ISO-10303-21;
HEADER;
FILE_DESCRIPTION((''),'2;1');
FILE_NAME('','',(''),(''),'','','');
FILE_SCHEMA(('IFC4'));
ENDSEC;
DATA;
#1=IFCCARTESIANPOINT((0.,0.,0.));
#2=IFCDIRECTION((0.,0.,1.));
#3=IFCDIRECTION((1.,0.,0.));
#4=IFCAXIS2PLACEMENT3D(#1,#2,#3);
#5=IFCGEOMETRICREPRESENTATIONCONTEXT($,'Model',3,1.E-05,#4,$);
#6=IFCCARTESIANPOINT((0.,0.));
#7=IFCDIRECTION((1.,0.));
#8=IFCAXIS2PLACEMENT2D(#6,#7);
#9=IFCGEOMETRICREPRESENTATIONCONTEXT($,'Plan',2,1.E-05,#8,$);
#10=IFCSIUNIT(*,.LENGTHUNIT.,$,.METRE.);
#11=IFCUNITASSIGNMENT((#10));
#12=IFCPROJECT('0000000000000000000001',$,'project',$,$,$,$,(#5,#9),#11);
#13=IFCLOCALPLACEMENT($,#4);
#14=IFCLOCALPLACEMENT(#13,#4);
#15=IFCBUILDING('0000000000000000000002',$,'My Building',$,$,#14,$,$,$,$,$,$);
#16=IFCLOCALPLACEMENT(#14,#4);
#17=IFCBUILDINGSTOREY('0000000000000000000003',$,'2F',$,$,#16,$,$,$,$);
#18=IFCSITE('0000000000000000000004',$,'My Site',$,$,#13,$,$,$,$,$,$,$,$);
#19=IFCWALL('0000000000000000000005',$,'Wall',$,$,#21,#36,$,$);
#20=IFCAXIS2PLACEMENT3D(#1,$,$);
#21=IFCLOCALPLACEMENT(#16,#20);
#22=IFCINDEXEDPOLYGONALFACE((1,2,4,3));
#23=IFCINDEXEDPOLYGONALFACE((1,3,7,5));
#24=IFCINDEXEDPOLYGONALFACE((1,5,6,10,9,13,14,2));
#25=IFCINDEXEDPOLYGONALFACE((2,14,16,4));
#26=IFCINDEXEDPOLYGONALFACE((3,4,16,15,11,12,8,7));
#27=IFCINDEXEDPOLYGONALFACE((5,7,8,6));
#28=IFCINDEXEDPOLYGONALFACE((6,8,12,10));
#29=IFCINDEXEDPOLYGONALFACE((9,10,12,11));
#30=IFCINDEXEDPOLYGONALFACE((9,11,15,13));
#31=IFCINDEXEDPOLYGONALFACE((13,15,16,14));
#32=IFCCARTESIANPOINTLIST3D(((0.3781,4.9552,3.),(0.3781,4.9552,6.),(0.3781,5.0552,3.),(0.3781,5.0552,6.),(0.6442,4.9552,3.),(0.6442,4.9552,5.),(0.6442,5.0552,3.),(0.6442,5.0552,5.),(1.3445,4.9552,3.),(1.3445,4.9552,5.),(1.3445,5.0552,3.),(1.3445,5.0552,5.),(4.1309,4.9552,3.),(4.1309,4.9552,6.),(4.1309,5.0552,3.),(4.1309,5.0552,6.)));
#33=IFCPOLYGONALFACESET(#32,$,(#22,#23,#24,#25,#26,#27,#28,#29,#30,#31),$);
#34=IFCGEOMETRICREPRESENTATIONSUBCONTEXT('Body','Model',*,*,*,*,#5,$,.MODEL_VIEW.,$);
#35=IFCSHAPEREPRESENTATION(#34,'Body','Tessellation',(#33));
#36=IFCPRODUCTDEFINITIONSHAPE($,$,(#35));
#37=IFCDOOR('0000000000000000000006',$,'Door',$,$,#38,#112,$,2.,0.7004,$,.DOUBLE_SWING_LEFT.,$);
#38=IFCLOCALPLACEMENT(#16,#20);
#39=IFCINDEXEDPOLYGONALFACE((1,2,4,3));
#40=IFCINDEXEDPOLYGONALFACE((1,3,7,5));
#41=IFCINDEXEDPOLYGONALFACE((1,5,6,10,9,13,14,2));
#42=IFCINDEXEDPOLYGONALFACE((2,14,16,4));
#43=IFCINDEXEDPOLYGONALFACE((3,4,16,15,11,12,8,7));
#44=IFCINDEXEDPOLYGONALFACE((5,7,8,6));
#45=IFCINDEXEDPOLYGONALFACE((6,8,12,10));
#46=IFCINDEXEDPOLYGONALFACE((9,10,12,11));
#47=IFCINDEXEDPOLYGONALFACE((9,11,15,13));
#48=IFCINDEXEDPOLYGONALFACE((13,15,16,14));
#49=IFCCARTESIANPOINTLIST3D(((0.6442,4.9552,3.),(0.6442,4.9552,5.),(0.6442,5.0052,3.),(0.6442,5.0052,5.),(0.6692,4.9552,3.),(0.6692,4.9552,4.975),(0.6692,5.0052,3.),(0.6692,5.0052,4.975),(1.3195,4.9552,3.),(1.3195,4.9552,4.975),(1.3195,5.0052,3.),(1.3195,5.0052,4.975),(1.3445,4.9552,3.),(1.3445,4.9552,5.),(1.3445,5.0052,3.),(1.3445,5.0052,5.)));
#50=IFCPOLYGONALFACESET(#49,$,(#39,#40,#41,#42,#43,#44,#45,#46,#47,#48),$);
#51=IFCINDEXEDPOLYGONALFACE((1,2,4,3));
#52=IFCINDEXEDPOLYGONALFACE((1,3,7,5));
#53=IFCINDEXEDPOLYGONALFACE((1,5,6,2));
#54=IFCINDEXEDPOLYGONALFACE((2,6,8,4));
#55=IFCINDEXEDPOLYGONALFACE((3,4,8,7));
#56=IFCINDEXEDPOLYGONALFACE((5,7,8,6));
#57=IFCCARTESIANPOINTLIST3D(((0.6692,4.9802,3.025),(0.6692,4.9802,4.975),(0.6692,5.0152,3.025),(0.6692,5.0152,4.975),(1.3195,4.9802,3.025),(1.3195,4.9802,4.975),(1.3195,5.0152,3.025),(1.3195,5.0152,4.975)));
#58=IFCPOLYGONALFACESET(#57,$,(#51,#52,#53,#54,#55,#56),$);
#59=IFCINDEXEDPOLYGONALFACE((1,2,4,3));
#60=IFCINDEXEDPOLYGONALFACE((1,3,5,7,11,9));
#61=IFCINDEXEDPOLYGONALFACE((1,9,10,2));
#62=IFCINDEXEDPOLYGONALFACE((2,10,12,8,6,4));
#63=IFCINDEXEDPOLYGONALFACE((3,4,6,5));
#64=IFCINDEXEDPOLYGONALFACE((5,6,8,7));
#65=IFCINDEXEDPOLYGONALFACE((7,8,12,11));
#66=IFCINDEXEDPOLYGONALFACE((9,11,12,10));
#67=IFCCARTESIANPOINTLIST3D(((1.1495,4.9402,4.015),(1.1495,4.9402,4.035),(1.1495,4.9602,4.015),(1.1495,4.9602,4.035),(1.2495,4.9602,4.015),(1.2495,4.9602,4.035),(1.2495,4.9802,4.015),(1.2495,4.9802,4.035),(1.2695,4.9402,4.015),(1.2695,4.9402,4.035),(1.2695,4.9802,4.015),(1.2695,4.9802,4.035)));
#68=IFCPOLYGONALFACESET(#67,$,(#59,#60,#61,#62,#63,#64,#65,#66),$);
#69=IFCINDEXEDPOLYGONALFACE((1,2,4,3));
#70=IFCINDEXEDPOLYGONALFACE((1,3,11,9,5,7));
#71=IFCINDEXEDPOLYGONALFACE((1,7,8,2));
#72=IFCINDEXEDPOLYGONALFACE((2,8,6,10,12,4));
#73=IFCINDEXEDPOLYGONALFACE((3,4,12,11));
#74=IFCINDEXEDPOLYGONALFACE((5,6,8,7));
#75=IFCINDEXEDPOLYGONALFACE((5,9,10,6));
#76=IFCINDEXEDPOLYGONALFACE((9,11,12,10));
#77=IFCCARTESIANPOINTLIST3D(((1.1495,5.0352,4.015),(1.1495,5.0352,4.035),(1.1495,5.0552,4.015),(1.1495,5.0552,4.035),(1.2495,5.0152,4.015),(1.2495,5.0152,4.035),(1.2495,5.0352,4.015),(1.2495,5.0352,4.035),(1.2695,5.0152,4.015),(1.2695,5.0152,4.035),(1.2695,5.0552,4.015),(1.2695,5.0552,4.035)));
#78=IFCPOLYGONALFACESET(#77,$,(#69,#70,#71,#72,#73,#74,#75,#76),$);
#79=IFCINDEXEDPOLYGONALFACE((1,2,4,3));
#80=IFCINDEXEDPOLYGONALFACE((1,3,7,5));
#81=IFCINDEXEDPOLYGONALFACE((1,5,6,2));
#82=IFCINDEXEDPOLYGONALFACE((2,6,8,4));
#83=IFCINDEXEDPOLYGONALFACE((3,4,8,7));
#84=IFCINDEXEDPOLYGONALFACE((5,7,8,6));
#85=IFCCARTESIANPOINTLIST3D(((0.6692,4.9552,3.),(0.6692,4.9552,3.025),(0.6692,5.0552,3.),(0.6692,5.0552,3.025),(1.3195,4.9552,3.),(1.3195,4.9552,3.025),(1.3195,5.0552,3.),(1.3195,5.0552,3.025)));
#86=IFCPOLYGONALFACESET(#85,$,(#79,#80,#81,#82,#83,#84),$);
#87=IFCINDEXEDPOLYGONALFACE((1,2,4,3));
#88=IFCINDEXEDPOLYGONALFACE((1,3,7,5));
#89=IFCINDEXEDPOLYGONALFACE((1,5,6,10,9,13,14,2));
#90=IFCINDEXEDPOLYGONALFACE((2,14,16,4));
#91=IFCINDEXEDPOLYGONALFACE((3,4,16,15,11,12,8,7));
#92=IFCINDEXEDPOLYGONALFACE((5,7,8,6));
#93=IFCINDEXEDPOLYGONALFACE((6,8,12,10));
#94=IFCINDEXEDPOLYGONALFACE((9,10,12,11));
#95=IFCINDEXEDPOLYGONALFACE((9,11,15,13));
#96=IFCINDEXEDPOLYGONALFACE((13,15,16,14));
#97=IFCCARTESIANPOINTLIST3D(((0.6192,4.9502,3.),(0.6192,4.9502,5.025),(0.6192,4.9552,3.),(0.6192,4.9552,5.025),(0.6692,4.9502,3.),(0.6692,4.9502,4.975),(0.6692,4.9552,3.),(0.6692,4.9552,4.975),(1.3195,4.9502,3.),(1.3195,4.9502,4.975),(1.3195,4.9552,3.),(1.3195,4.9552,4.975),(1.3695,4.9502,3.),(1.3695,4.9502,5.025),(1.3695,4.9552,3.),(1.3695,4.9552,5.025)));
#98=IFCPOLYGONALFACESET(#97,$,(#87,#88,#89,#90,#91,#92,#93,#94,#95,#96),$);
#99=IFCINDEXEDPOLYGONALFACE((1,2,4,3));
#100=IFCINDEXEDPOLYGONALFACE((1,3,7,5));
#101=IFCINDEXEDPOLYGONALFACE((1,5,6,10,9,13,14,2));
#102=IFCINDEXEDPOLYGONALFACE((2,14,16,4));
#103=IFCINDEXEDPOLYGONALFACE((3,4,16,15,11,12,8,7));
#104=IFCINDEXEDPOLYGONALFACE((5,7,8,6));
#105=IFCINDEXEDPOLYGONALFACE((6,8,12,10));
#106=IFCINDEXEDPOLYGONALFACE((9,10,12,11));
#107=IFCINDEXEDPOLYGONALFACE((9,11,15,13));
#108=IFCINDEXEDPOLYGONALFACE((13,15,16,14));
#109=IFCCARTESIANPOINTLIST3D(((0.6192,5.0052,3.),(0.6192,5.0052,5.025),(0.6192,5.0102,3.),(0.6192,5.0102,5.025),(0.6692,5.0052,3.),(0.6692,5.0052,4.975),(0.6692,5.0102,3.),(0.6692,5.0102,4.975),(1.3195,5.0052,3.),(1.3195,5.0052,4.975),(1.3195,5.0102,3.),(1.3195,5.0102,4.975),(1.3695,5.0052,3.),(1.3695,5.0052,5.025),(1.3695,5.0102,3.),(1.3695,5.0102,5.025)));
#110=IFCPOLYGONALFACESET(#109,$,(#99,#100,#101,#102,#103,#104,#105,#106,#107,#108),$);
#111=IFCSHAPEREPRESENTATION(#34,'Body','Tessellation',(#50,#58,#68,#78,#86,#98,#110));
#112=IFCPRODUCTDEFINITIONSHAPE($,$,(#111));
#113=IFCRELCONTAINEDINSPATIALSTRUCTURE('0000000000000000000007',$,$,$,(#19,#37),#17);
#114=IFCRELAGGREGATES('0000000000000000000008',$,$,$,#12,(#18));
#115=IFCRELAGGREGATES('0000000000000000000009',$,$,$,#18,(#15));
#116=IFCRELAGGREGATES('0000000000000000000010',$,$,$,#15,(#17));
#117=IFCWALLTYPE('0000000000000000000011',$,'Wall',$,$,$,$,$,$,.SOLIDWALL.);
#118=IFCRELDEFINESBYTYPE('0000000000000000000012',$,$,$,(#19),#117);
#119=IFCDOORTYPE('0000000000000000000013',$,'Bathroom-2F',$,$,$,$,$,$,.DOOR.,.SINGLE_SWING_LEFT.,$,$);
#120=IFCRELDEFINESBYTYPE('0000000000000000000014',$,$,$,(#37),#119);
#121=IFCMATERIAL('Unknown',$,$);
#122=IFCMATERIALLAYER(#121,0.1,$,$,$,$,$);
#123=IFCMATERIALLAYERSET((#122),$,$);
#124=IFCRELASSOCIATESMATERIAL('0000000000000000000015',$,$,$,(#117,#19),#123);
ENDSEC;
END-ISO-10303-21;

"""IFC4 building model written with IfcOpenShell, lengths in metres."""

from ifc_helpers import new_model, entity, si_unit, frame, origin_with_axes, origin_2d_with_axis, place, context, subcontext, project, spatial, line, indexed_curve, outline, extrude, shape, source, transform, mapped, material, layer, layer_set, layer_usage, type_object, type_shapes, element, fill, save


model = new_model("IFC4")

# Units and contexts
model_context = context("Model", 3, precision=1e-05, world=origin_with_axes())
plan_context = context("Plan", 2, precision=1e-05, world=origin_2d_with_axis())
body_context_1 = subcontext(model_context, "Body", "Model", "MODEL_VIEW")
body_context_2 = subcontext(plan_context, "Body", "Plan", "PLAN_VIEW")
ifc_project = project(units=[si_unit("LENGTHUNIT", "METRE")], contexts=[model_context, plan_context])

# Site, building, storey
site_placement = place(None, origin_with_axes())
site = spatial("IfcSite", under=ifc_project, at=site_placement, Name="My Site")
building_placement = place(site_placement, origin_with_axes())
building = spatial("IfcBuilding", under=site, at=building_placement, Name="My Building")
storey_placement = place(building_placement, origin_with_axes())
storey = spatial("IfcBuildingStorey", under=building, at=storey_placement, Name="2F")

# Shared definitions
ifc_material = material(Name="Unknown")

# Shared definitions
ifc_layer = layer(ifc_material, 0.1)
ifc_layer_set = layer_set([ifc_layer])
wall_type = type_object("IfcWallType", Name="Wall", PredefinedType="SOLIDWALL", material=ifc_layer_set)

# Wall, opening, door
ifc_layer_usage_1 = layer_usage(ifc_layer_set, "AXIS2", "POSITIVE", 0.0)
wall_1_placement = place(storey_placement, frame((4.2309, 5.0552, 3.0), z_axis=(0.0, 0.0, 1.0), x_axis=(-1.0, 0.0, 0.0)))
wall_1 = element("IfcWall", 1, at=wall_1_placement, inside=storey, type_object=wall_type, material=ifc_layer_usage_1, Name="Wall", context=body_context_1, shape_type="SweptSolid", body=[
    extrude(outline(indexed_curve([(0.1, 0.0), (0.1, 0.1), (3.8528, 0.1), (3.8528, 0.0)], segments=[line(1, 2, 3, 4, 1)])), origin_with_axes(), (0.0, 0.0, 1.0), 3.0),
])
shared_shape_1 = source(origin_with_axes(), body_context_1, "Body", "SweptSolid", [
    extrude(outline(indexed_curve([(0.0, 0.0), (0.7004, 0.0), (0.7004, 2.0), (0.0, 2.0)], segments=[line(1, 2, 3, 4, 1)])), frame((0.0, -0.6, 0.0), z_axis=(0.0, -1.0, 0.0), x_axis=(1.0, 0.0, 0.0)), (0.0, 0.0, -1.0), 1.2),
])
opening_1_placement = place(wall_1_placement, frame((3.5867, 0.1, 0.0), z_axis=(0.0, 0.0, 1.0), x_axis=(-1.0, 0.0, 0.0)))
opening_1 = element("IfcOpeningElement", 2, at=opening_1_placement, cuts=wall_1, PredefinedType="OPENING", context=body_context_1, shape_type="MappedRepresentation", body=[
    mapped(shared_shape_1, transform((0.0, 0.0, 0.0), x_axis=(1.0, 0.0, 0.0), y_axis=(0.0, 1.0, 0.0), z_axis=(0.0, 0.0, 1.0), scale=1.0)),
])
door_type_1 = type_object("IfcDoorType", Name="Bathroom-2F", OperationType="SINGLE_SWING_LEFT", PredefinedType="DOOR")
shared_shape_2 = source(origin_with_axes(), body_context_1, "Body", "SweptSolid", [
    extrude(outline(indexed_curve([(0.0, 0.0), (0.0, 2.0), (0.7004, 2.0), (0.7004, 0.0), (0.6754, 0.0), (0.6754, 1.975), (0.025, 1.975), (0.025, 0.0)], segments=[line(1, 2, 3, 4, 5, 6, 7, 8, 1)])), frame((0.0, 0.0, 0.0), z_axis=(0.0, -1.0, 0.0), x_axis=(1.0, 0.0, 0.0)), (0.0, 0.0, -1.0), 0.05),
    extrude(outline(indexed_curve([(0.0, 0.0), (0.6504, 0.0), (0.6504, 0.035), (0.0, 0.035)], segments=[line(1, 2, 3, 4, 1)])), frame((0.025, 0.025, 0.025), z_axis=(0.0, 0.0, 1.0), x_axis=(1.0, 0.0, 0.0)), (0.0, 0.0, 1.0), 1.95),
    extrude(outline(indexed_curve([(0.0, 0.0), (0.0, -0.04), (-0.12, -0.04), (-0.12, -0.02), (-0.02, -0.02), (-0.02, 0.0)], segments=[line(1, 2, 3, 4, 5, 6, 1)])), frame((0.6254, 0.025, 1.015), z_axis=(0.0, 0.0, 1.0), x_axis=(1.0, 0.0, 0.0)), (0.0, 0.0, 1.0), 0.02),
    extrude(outline(indexed_curve([(0.0, 0.0), (0.0, 0.04), (-0.12, 0.04), (-0.12, 0.02), (-0.02, 0.02), (-0.02, 0.0)], segments=[line(1, 2, 3, 4, 5, 6, 1)])), frame((0.6254, 0.06, 1.015), z_axis=(0.0, 0.0, 1.0), x_axis=(1.0, 0.0, 0.0)), (0.0, 0.0, 1.0), 0.02),
    extrude(outline(indexed_curve([(0.0, 0.0), (0.6504, 0.0), (0.6504, 0.1), (0.0, 0.1)], segments=[line(1, 2, 3, 4, 1)])), frame((0.025, 0.0, 0.0), z_axis=(0.0, 0.0, 1.0), x_axis=(1.0, 0.0, 0.0)), (0.0, 0.0, 1.0), 0.025),
    extrude(outline(indexed_curve([(0.0, 0.0), (0.0, 2.025), (0.7504, 2.025), (0.7504, 0.0), (0.7004, 0.0), (0.7004, 1.975), (0.05, 1.975), (0.05, 0.0)], segments=[line(1, 2, 3, 4, 5, 6, 7, 8, 1)])), frame((-0.025, -0.005, 0.0), z_axis=(0.0, -1.0, 0.0), x_axis=(1.0, 0.0, 0.0)), (0.0, 0.0, -1.0), 0.005),
    extrude(outline(indexed_curve([(0.0, 0.0), (0.0, 2.025), (0.7504, 2.025), (0.7504, 0.0), (0.7004, 0.0), (0.7004, 1.975), (0.05, 1.975), (0.05, 0.0)], segments=[line(1, 2, 3, 4, 5, 6, 7, 8, 1)])), frame((-0.025, 0.05, 0.0), z_axis=(0.0, -1.0, 0.0), x_axis=(1.0, 0.0, 0.0)), (0.0, 0.0, -1.0), 0.005),
])
shared_shape_3 = source(origin_with_axes(), body_context_2, "Body", "Curve2D", [
    entity("IfcIndexedPolyCurve", entity("IfcCartesianPointList2D", [[0.0, 0.0], [0.025, 0.0], [0.025, 0.05], [0.0, 0.05]]), [entity("IfcLineIndex", [1, 2, 3, 4, 1])]),
    entity("IfcIndexedPolyCurve", entity("IfcCartesianPointList2D", [[0.7004, 0.0], [0.6754, 0.0], [0.6754, 0.05], [0.7004, 0.05]]), [entity("IfcLineIndex", [1, 2, 3, 4, 1])]),
    entity("IfcIndexedPolyCurve", entity("IfcCartesianPointList2D", [[0.025, 0.05], [0.025, -0.6004], [0.06, -0.6004]])),
    entity("IfcTrimmedCurve", entity("IfcEllipse", entity("IfcAxis2Placement2D", entity("IfcCartesianPoint", [0.06, 0.05]), entity("IfcDirection", [1.0, 0.0])), 0.6154, 0.6504), [entity("IfcCartesianPoint", [0.06, -0.6004])], [entity("IfcCartesianPoint", [0.06, 0.7004])], True, "CARTESIAN"),
    entity("IfcIndexedPolyCurve", entity("IfcCartesianPointList2D", [[0.025, 0.05], [0.06, 0.05], [0.06, 0.7004], [0.025, 0.7004]]), [entity("IfcLineIndex", [1, 2, 3, 4, 1])]),
])
type_shapes(door_type_1, [shared_shape_2, shared_shape_3])
door_1_placement = place(opening_1_placement, origin_with_axes())
door_1 = element("IfcDoor", 3, at=door_1_placement, inside=storey, type_object=door_type_1, Name="Door", OperationType="DOUBLE_SWING_LEFT", OverallHeight=2.0, OverallWidth=0.7004, shapes=[
    shape(body_context_1, "Body", "MappedRepresentation", [mapped(shared_shape_2, transform((0.0, 0.0, 0.0), x_axis=(1.0, 0.0, 0.0), y_axis=(0.0, 1.0, 0.0), z_axis=(0.0, 0.0, 1.0), scale=1.0))]),
    shape(body_context_2, "Body", "MappedRepresentation", [mapped(shared_shape_3, transform((0.0, 0.0, 0.0), x_axis=(1.0, 0.0, 0.0), y_axis=(0.0, 1.0, 0.0), z_axis=(0.0, 0.0, 1.0), scale=1.0))]),
])
fill(opening_1, door_1)

save(model, "model.ifc")
